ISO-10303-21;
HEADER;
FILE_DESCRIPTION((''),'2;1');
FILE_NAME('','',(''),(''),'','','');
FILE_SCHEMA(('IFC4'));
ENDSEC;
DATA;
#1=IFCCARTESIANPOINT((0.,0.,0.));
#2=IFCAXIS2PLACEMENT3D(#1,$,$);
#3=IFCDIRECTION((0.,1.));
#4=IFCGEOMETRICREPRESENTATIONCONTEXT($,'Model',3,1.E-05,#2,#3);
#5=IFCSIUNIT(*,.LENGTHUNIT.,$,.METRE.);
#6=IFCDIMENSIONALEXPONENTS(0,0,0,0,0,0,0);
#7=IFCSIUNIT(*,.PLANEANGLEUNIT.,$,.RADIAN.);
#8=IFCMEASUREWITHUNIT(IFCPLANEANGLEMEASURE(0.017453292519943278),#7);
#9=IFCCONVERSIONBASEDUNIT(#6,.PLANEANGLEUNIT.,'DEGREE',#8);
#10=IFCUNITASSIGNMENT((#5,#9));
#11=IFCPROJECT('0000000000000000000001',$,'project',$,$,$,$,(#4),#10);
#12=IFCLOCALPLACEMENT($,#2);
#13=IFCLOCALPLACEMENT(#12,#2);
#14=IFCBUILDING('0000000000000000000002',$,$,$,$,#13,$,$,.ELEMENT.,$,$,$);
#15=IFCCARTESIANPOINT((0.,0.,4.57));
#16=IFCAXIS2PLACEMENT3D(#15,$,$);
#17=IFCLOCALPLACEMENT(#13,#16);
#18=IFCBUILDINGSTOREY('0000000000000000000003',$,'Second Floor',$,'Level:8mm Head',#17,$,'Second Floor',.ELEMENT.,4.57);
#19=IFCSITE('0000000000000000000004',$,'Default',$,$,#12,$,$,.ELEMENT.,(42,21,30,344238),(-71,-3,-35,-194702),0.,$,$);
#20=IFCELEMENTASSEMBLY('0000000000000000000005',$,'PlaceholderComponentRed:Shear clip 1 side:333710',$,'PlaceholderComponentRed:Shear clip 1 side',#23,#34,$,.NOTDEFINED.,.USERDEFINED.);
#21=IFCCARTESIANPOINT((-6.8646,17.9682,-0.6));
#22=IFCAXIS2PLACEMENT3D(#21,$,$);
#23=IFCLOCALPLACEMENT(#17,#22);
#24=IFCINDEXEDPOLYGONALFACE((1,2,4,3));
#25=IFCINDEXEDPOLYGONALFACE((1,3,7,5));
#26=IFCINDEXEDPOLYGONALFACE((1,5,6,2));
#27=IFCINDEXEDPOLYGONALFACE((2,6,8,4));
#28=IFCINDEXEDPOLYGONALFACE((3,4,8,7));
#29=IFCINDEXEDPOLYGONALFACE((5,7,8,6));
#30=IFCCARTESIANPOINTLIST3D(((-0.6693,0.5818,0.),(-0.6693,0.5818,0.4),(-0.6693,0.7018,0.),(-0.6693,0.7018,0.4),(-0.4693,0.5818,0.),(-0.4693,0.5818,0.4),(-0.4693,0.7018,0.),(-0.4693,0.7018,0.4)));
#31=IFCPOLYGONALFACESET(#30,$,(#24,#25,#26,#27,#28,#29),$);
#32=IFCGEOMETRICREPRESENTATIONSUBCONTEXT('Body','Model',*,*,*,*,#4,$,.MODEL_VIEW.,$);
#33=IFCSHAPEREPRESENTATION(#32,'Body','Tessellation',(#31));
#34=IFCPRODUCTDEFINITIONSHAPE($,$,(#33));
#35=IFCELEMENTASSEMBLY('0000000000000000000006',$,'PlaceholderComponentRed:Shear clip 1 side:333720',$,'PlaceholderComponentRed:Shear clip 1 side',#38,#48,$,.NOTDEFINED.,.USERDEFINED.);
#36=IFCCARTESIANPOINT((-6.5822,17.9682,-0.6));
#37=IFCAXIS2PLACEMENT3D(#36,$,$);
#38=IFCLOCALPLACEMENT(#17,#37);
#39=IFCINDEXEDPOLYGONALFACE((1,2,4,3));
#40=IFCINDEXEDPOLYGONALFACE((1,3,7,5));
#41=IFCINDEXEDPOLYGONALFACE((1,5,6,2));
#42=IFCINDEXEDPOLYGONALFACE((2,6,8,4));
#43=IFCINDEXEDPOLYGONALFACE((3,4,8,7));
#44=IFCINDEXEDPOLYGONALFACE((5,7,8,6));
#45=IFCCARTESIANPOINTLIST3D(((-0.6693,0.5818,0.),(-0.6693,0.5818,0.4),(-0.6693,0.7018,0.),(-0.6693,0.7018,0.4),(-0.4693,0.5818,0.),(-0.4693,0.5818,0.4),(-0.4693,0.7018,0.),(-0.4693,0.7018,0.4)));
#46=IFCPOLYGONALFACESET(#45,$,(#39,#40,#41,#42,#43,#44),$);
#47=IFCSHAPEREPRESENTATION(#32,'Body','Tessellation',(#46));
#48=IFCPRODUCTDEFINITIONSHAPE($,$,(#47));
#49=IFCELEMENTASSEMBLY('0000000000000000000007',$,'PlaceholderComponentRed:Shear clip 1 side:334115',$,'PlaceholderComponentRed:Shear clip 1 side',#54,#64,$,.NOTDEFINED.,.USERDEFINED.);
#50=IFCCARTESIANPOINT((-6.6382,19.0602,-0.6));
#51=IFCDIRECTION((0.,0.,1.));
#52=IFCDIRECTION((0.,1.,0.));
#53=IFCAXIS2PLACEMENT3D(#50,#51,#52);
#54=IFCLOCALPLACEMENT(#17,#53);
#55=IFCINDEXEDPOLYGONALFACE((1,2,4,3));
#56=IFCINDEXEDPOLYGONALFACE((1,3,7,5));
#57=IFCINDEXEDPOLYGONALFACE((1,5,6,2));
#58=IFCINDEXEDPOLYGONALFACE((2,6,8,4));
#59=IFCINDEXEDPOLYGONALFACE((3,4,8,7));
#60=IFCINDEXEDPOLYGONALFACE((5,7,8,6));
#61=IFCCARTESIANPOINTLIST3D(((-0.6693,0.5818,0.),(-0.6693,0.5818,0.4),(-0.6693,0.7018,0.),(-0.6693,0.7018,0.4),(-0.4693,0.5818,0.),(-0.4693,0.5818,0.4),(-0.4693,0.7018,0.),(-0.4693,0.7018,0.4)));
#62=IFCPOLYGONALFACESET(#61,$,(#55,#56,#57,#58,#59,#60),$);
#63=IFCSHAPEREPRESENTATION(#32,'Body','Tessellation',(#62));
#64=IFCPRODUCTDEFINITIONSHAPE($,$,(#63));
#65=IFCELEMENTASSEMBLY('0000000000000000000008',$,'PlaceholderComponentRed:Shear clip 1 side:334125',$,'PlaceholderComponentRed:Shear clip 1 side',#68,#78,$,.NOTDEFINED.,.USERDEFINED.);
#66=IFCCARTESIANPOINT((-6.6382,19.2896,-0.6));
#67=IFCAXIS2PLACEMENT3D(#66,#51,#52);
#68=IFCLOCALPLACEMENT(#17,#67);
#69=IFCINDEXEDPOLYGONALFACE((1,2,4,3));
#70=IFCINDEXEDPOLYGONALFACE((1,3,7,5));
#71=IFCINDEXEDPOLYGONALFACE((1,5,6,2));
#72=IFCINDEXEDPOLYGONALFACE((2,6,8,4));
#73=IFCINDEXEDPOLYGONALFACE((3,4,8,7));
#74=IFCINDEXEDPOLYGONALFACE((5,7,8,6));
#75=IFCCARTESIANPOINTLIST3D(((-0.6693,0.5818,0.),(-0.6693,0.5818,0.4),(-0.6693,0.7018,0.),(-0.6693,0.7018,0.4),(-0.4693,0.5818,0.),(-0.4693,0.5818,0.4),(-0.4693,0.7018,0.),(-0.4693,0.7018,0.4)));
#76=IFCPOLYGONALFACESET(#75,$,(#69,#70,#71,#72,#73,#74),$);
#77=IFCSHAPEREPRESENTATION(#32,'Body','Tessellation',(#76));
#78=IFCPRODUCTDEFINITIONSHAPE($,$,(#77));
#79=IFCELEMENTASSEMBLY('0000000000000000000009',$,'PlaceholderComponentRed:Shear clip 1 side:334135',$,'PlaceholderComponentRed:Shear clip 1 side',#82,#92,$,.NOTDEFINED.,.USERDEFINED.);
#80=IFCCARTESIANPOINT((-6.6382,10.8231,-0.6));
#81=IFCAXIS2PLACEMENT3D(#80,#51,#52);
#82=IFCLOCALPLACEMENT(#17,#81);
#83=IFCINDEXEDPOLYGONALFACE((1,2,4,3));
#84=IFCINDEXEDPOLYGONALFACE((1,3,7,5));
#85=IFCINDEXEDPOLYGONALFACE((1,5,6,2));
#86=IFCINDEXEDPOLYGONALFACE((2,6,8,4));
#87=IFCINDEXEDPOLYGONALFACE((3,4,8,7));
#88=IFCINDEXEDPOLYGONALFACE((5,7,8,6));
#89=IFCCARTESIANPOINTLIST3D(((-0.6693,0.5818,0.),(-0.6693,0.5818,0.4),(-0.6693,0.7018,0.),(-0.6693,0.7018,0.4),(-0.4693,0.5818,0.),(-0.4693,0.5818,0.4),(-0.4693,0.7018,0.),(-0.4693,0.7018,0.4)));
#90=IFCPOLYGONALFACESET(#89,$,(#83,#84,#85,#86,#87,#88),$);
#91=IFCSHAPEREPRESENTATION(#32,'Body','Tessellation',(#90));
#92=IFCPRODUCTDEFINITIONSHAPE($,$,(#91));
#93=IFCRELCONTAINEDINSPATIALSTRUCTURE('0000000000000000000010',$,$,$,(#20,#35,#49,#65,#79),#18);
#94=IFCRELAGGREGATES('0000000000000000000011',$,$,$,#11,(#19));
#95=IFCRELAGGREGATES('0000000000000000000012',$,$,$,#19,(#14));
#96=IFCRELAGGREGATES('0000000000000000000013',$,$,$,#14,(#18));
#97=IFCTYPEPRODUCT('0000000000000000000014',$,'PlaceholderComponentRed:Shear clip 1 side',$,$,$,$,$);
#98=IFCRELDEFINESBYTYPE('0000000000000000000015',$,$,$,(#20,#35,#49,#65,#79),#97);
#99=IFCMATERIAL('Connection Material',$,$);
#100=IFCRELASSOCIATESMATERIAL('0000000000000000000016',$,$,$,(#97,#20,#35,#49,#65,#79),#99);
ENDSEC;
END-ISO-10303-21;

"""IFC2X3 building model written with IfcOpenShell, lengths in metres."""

from ifc_helpers import new_model, entity, si_unit, converted_unit, direction, frame, frame_2d, origin, place, context, subcontext, project, spatial, rectangle, extrude, source, transform, mapped, material, type_object, type_shapes, element, save


model = new_model("IFC2X3")

# Units and contexts
model_context = context("Model", 3, precision=1e-05, world=origin(), true_north=direction((0.0, 1.0)))
body_context = subcontext(model_context, "Body", "Model", "MODEL_VIEW")
ifc_project = project(units=[si_unit("LENGTHUNIT", "METRE"), converted_unit("PLANEANGLEUNIT", "DEGREE", entity("IfcPlaneAngleMeasure", 0.017453292519943278), si_unit("PLANEANGLEUNIT", "RADIAN"), dimensions=[0, 0, 0, 0, 0, 0, 0])], contexts=[model_context])

# Site, building, storey
site_placement = place(None, origin())
site = spatial("IfcSite", under=ifc_project, at=site_placement, Name="Default", CompositionType="ELEMENT", RefLatitude=(42, 21, 30, 344238), RefLongitude=(-71, -3, -35, -194702), RefElevation=0.0)
building_placement = place(site_placement, origin())
building = spatial("IfcBuilding", under=site, at=building_placement, CompositionType="ELEMENT")
storey_placement = place(building_placement, frame((0.0, 0.0, 4.57)))
storey = spatial("IfcBuildingStorey", under=building, at=storey_placement, Name="Second Floor", ObjectType="Level:8mm Head", LongName="Second Floor", CompositionType="ELEMENT", Elevation=4.57)

# Element assemblies
ifc_material_1 = material(Name="Connection Material")
type_product = type_object("IfcTypeProduct", Name="PlaceholderComponentRed:Shear clip 1 side", material=ifc_material_1)
shared_shape_1 = source(origin(), body_context, "Body", "SweptSolid", [
    extrude(rectangle(XDim=0.12, YDim=0.2, at=frame_2d((0.0, 0.0), x_axis=(1.0, 0.0))), frame((-0.5693, 0.6418, 0.0), z_axis=(0.0, 0.0, 1.0), x_axis=(0.0, 1.0, 0.0)), (0.0, 0.0, 1.0), 0.4),
])
type_shapes(type_product, [shared_shape_1])
for number, where, name in (
    (1, (-6.8646, 17.9682, -0.6), "PlaceholderComponentRed:Shear clip 1 side:333710"),
    (2, (-6.5822, 17.9682, -0.6), "PlaceholderComponentRed:Shear clip 1 side:333720"),
):
    element("IfcElementAssembly", number, at=place(storey_placement, frame(where)), inside=storey, type_object=type_product, material=ifc_material_1, Name=name, ObjectType="PlaceholderComponentRed:Shear clip 1 side", AssemblyPlace="NOTDEFINED", PredefinedType="USERDEFINED", context=body_context, shape_type="MappedRepresentation", body=[
        mapped(shared_shape_1, transform((0.0, 0.0, 0.0), scale=1.0)),
    ])
for number, where, z_axis, x_axis, name in (
    (3, (-6.6382, 19.0602, -0.6), (0.0, 0.0, 1.0), (0.0, 1.0, 0.0), "PlaceholderComponentRed:Shear clip 1 side:334115"),
    (4, (-6.6382, 19.2896, -0.6), (0.0, 0.0, 1.0), (0.0, 1.0, 0.0), "PlaceholderComponentRed:Shear clip 1 side:334125"),
    (5, (-6.6382, 10.8231, -0.6), (0.0, 0.0, 1.0), (0.0, 1.0, 0.0), "PlaceholderComponentRed:Shear clip 1 side:334135"),
):
    element("IfcElementAssembly", number, at=place(storey_placement, frame(where, z_axis=z_axis, x_axis=x_axis)), inside=storey, type_object=type_product, material=ifc_material_1, Name=name, ObjectType="PlaceholderComponentRed:Shear clip 1 side", AssemblyPlace="NOTDEFINED", PredefinedType="USERDEFINED", context=body_context, shape_type="MappedRepresentation", body=[
        mapped(shared_shape_1, transform((0.0, 0.0, 0.0), scale=1.0)),
    ])

save(model, "model.ifc")
